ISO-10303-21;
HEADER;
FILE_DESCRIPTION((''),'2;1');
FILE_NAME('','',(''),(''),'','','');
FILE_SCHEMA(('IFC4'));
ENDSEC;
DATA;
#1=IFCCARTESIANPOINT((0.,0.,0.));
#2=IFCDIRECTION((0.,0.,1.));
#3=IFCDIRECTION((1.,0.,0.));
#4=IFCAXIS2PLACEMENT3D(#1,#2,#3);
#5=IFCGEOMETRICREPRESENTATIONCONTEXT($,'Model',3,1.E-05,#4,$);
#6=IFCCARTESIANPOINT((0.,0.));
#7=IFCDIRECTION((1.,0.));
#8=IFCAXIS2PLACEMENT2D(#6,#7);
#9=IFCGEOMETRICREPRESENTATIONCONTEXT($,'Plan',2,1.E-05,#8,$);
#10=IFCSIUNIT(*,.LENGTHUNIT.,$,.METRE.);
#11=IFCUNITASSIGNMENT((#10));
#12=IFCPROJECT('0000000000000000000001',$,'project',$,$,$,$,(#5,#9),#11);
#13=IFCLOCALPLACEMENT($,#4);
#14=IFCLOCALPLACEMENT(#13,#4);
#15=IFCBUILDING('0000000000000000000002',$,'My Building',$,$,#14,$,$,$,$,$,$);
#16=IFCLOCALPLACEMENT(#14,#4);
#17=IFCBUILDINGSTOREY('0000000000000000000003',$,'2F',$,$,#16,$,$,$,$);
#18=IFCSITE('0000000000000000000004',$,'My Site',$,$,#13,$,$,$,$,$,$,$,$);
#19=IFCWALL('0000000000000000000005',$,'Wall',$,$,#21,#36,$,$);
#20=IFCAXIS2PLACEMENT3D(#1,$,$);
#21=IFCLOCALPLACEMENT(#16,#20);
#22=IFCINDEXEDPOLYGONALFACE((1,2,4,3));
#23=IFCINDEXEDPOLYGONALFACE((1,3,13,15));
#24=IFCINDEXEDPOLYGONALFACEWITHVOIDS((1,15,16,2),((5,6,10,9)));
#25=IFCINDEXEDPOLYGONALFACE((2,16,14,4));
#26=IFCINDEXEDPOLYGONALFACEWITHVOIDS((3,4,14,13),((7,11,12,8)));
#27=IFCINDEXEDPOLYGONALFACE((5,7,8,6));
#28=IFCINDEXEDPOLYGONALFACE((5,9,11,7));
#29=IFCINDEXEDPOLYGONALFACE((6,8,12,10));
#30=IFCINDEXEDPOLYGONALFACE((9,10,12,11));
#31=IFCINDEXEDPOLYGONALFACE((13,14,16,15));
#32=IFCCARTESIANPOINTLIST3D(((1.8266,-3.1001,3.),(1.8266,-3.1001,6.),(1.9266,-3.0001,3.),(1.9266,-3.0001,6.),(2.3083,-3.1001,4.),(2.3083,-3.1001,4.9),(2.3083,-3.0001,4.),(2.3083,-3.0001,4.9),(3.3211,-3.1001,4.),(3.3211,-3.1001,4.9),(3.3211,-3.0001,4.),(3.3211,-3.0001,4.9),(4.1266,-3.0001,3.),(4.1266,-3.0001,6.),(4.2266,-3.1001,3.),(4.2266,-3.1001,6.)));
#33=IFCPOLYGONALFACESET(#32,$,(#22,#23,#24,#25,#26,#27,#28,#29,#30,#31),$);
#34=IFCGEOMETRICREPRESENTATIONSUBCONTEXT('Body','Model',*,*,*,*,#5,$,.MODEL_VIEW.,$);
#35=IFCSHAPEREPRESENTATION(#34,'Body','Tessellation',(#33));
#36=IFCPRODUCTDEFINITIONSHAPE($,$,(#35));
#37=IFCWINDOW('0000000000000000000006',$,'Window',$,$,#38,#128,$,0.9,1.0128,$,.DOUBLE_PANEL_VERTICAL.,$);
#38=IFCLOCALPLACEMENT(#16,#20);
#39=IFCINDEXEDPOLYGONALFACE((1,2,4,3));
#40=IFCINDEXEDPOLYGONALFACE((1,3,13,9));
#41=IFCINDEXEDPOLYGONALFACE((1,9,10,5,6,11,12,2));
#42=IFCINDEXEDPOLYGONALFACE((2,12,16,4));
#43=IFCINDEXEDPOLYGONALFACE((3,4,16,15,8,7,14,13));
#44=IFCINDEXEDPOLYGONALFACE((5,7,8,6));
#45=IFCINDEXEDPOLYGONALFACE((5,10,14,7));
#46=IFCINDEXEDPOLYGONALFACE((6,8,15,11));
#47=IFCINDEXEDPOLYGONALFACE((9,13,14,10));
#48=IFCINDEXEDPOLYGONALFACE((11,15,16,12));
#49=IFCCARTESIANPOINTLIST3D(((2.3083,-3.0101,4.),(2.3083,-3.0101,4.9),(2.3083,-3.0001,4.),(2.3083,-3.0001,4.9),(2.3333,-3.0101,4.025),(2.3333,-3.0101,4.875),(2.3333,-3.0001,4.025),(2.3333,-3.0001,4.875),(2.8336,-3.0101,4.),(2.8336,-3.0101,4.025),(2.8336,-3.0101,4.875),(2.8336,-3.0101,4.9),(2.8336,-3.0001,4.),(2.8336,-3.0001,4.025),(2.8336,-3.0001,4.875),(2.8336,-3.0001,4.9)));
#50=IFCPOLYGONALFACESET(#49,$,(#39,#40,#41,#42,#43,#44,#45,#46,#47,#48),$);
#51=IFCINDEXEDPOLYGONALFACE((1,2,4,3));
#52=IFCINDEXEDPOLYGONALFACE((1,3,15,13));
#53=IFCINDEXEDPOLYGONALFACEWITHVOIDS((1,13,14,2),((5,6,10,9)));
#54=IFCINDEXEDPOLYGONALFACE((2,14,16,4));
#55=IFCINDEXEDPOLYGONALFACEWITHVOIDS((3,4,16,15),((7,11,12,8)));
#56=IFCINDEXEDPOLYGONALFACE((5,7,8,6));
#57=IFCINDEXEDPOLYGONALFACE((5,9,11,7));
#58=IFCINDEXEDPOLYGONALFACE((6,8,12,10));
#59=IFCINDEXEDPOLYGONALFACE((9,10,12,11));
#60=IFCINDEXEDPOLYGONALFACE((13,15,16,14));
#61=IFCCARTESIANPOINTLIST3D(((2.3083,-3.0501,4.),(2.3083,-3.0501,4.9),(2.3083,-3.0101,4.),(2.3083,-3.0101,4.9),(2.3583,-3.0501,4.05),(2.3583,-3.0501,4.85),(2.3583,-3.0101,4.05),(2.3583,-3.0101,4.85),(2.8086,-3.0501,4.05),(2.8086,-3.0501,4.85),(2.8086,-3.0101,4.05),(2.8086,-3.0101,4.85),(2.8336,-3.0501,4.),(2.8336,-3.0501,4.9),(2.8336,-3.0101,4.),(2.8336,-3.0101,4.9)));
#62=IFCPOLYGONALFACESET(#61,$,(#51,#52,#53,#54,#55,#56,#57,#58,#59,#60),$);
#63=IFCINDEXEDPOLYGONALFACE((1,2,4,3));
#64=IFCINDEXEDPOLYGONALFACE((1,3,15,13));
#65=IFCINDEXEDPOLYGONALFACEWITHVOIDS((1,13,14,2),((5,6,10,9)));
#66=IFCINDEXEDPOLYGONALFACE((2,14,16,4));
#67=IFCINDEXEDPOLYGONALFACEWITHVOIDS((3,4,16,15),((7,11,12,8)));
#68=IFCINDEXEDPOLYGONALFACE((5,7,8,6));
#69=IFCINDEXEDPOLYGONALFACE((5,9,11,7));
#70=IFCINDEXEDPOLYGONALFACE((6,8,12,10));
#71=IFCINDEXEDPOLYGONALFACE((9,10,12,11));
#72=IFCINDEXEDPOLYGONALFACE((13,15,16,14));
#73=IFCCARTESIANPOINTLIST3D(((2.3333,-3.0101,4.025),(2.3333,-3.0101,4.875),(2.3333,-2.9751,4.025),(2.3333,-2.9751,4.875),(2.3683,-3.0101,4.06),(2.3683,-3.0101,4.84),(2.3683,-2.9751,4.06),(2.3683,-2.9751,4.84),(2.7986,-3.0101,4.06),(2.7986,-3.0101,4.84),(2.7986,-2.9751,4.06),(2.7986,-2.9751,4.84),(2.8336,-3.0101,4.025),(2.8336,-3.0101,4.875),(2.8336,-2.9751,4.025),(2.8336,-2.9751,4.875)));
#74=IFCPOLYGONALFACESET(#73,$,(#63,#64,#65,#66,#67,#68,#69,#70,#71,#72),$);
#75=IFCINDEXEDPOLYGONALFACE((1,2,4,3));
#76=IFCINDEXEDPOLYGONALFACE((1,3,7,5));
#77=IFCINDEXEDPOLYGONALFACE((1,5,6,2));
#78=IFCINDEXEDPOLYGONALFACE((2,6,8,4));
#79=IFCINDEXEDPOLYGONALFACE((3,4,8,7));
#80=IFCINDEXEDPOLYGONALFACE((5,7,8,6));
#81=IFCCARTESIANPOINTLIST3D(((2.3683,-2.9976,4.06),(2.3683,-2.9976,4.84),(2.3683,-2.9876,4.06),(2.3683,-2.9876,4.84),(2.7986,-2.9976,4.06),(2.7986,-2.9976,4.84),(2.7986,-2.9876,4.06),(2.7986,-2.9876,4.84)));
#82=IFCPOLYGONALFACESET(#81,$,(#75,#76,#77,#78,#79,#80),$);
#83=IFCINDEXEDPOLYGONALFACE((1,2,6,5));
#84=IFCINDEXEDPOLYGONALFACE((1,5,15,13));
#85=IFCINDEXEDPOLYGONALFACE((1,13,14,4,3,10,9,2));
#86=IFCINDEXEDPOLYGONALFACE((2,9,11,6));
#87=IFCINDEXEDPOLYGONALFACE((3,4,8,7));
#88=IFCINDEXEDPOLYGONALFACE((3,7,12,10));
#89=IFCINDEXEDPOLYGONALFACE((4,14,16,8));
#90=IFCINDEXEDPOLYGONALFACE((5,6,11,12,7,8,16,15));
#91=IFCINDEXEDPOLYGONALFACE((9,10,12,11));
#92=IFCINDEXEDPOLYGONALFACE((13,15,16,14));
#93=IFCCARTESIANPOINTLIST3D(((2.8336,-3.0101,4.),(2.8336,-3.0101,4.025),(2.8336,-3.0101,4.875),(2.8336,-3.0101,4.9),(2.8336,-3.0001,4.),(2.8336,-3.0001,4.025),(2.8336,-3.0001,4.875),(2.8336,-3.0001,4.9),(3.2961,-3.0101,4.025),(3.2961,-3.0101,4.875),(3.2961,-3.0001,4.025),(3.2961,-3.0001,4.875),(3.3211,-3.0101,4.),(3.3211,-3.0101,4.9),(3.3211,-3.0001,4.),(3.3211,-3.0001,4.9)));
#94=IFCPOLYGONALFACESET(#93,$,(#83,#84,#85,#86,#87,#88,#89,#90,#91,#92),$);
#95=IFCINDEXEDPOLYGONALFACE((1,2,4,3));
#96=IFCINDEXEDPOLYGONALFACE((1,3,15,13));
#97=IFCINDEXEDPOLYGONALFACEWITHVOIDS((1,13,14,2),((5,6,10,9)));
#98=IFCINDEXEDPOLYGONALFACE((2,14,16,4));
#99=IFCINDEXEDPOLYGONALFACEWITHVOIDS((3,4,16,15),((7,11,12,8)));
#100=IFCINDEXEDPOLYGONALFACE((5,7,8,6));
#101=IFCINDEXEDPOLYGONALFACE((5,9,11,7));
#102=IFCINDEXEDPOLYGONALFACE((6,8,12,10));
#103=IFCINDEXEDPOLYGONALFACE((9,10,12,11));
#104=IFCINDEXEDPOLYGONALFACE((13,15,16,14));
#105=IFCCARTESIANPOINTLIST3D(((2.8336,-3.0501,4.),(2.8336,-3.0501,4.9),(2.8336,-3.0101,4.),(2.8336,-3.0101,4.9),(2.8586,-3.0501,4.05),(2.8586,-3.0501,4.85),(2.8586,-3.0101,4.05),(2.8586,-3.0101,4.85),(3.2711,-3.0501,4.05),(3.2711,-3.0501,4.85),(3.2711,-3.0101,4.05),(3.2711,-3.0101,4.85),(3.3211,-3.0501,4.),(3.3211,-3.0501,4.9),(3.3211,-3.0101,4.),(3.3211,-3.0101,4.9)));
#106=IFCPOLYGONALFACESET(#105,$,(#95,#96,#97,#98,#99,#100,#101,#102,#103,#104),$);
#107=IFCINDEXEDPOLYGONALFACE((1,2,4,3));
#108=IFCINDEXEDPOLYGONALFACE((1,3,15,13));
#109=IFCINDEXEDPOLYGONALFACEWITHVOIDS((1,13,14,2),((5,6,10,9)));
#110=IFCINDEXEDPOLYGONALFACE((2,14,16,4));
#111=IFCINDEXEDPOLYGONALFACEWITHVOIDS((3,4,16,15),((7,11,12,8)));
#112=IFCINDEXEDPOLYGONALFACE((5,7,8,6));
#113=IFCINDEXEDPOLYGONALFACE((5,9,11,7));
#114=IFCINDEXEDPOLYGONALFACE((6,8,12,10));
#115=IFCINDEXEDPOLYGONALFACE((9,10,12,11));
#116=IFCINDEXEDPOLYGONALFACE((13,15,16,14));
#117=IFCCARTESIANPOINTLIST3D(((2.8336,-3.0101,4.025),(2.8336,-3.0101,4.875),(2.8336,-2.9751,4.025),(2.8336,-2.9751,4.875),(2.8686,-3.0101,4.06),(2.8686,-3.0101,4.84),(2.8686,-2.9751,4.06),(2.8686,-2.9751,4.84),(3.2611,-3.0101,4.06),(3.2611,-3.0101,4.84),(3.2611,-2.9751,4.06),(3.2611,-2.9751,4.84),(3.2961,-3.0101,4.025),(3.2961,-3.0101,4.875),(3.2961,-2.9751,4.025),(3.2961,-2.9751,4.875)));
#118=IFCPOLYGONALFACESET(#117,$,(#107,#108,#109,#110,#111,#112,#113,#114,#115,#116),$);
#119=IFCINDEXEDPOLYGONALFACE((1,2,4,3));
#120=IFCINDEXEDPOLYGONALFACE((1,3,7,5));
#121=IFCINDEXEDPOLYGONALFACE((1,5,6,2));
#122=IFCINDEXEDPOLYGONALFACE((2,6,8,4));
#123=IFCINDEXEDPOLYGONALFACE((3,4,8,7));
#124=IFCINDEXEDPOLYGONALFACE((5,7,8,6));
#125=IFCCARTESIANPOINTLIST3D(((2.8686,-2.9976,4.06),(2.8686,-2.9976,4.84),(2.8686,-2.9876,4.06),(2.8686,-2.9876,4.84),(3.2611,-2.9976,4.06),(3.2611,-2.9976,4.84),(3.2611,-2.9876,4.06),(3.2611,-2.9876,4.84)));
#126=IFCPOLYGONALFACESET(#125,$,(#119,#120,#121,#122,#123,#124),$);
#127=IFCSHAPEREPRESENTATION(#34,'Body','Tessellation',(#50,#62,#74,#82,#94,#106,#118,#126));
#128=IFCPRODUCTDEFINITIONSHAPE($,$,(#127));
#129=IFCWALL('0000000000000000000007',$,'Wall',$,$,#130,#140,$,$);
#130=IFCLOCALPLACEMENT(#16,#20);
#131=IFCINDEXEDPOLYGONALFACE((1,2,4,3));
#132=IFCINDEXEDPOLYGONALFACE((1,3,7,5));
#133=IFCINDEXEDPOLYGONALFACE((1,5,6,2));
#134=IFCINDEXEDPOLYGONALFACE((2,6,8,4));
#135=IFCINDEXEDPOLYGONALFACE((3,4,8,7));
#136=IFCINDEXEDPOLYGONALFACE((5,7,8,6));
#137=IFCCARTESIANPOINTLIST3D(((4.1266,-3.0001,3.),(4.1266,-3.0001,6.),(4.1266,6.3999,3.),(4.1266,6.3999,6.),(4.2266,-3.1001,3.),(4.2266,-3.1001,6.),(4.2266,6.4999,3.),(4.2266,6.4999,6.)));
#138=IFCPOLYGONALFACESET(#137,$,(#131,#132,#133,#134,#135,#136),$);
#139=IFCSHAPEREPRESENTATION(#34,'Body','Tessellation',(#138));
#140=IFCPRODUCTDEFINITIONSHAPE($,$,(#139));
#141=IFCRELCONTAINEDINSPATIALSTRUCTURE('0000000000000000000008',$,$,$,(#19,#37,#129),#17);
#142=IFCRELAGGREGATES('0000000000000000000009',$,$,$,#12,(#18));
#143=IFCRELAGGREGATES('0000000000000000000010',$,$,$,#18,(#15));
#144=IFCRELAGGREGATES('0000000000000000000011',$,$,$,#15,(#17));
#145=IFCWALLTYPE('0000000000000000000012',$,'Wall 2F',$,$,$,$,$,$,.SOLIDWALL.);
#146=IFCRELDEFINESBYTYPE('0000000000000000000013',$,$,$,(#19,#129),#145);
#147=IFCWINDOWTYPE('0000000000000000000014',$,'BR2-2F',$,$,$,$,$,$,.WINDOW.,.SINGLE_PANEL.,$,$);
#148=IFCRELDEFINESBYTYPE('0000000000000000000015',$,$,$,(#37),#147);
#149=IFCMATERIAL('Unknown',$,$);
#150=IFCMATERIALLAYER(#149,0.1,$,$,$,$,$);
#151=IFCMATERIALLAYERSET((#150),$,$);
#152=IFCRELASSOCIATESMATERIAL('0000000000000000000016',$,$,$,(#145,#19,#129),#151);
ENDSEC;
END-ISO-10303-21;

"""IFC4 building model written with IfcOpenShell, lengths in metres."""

from ifc_helpers import new_model, entity, si_unit, frame, origin_with_axes, origin_2d_with_axis, place, context, subcontext, project, spatial, line, indexed_curve, outline, extrude, shape, source, transform, mapped, material, layer, layer_set, layer_usage, type_object, type_shapes, element, fill, save


model = new_model("IFC4")

# Units and contexts
model_context = context("Model", 3, precision=1e-05, world=origin_with_axes())
plan_context = context("Plan", 2, precision=1e-05, world=origin_2d_with_axis())
body_context_1 = subcontext(model_context, "Body", "Model", "MODEL_VIEW")
body_context_2 = subcontext(plan_context, "Body", "Plan", "PLAN_VIEW")
ifc_project = project(units=[si_unit("LENGTHUNIT", "METRE")], contexts=[model_context, plan_context])

# Site, building, storey
site_placement = place(None, origin_with_axes())
site = spatial("IfcSite", under=ifc_project, at=site_placement, Name="My Site")
building_placement = place(site_placement, origin_with_axes())
building = spatial("IfcBuilding", under=site, at=building_placement, Name="My Building")
storey_placement = place(building_placement, origin_with_axes())
storey = spatial("IfcBuildingStorey", under=building, at=storey_placement, Name="2F")

# Shared definitions
ifc_material = material(Name="Unknown")

# Shared definitions
ifc_layer = layer(ifc_material, 0.1)
ifc_layer_set = layer_set([ifc_layer])
wall_type = type_object("IfcWallType", Name="Wall 2F", PredefinedType="SOLIDWALL", material=ifc_layer_set)

# Wall, opening, window
ifc_layer_usage_1 = layer_usage(ifc_layer_set, "AXIS2", "POSITIVE", 0.0)
wall_1_placement = place(storey_placement, frame((1.8266, -3.1001, 3.0), z_axis=(0.0, 0.0, 1.0), x_axis=(1.0, 0.0, 0.0)))
wall_1 = element("IfcWall", 1, at=wall_1_placement, inside=storey, type_object=wall_type, material=ifc_layer_usage_1, Name="Wall", context=body_context_1, shape_type="SweptSolid", body=[
    extrude(outline(indexed_curve([(0.0, 0.0), (0.1, 0.1), (2.3, 0.1), (2.4, 0.0)], segments=[line(1, 2, 3, 4, 1)])), origin_with_axes(), (0.0, 0.0, 1.0), 3.0),
])
shared_shape_1 = source(origin_with_axes(), body_context_1, "Body", "SweptSolid", [
    extrude(outline(indexed_curve([(0.0, 0.0), (1.0128, 0.0), (1.0128, 0.9), (0.0, 0.9)], segments=[line(1, 2, 3, 4, 1)])), frame((0.0, -0.6, 0.0), z_axis=(0.0, -1.0, 0.0), x_axis=(1.0, 0.0, 0.0)), (0.0, 0.0, -1.0), 1.2),
])
opening_1_placement = place(wall_1_placement, frame((0.4817, 0.0, 1.0), z_axis=(0.0, 0.0, 1.0), x_axis=(1.0, 0.0, 0.0)))
opening_1 = element("IfcOpeningElement", 2, at=opening_1_placement, cuts=wall_1, PredefinedType="OPENING", context=body_context_1, shape_type="MappedRepresentation", body=[
    mapped(shared_shape_1, transform((0.0, 0.0, 0.0), x_axis=(1.0, 0.0, 0.0), y_axis=(0.0, 1.0, 0.0), z_axis=(0.0, 0.0, 1.0), scale=1.0)),
])
window_type = type_object("IfcWindowType", Name="BR2-2F", PartitioningType="SINGLE_PANEL", PredefinedType="WINDOW")
shared_shape_2 = source(origin_with_axes(), body_context_1, "Body", "SweptSolid", [
    extrude(outline(indexed_curve([(0.5254, 0.0), (0.0, 0.0), (0.0, 0.9), (0.5254, 0.9), (0.5254, 0.875), (0.025, 0.875), (0.025, 0.025), (0.5254, 0.025)], segments=[line(1, 2, 3, 4, 5, 6, 7, 8, 1)])), frame((0.0, 0.09, 0.0), z_axis=(0.0, -1.0, 0.0), x_axis=(1.0, 0.0, 0.0)), (0.0, 0.0, -1.0), 0.01),
    extrude(outline(indexed_curve([(0.0, 0.0), (0.5254, 0.0), (0.5254, 0.9), (0.0, 0.9)], segments=[line(1, 2, 3, 4, 1)]), holes=[indexed_curve([(0.05, 0.05), (0.5004, 0.05), (0.5004, 0.85), (0.05, 0.85)], segments=[line(1, 2, 3, 4, 1)])]), frame((0.0, 0.05, 0.0), z_axis=(0.0, -1.0, 0.0), x_axis=(1.0, 0.0, 0.0)), (0.0, 0.0, -1.0), 0.04),
    extrude(outline(indexed_curve([(0.0, 0.0), (0.5004, 0.0), (0.5004, 0.85), (0.0, 0.85)], segments=[line(1, 2, 3, 4, 1)]), holes=[indexed_curve([(0.035, 0.035), (0.4654, 0.035), (0.4654, 0.815), (0.035, 0.815)], segments=[line(1, 2, 3, 4, 1)])]), frame((0.025, 0.09, 0.025), z_axis=(0.0, -1.0, 0.0), x_axis=(1.0, 0.0, 0.0)), (0.0, 0.0, -1.0), 0.035),
    extrude(outline(indexed_curve([(0.035, 0.035), (0.4654, 0.035), (0.4654, 0.815), (0.035, 0.815)], segments=[line(1, 2, 3, 4, 1)])), frame((0.025, 0.1025, 0.025), z_axis=(0.0, -1.0, 0.0), x_axis=(1.0, 0.0, 0.0)), (0.0, 0.0, -1.0), 0.01),
    extrude(outline(indexed_curve([(0.0, 0.9), (0.4875, 0.9), (0.4875, 0.0), (0.0, 0.0), (0.0, 0.025), (0.4625, 0.025), (0.4625, 0.875), (0.0, 0.875)], segments=[line(1, 2, 3, 4, 5, 6, 7, 8, 1)])), frame((0.5254, 0.09, 0.0), z_axis=(0.0, -1.0, 0.0), x_axis=(1.0, 0.0, 0.0)), (0.0, 0.0, -1.0), 0.01),
    extrude(outline(indexed_curve([(0.0, 0.0), (0.4875, 0.0), (0.4875, 0.9), (0.0, 0.9)], segments=[line(1, 2, 3, 4, 1)]), holes=[indexed_curve([(0.025, 0.05), (0.4375, 0.05), (0.4375, 0.85), (0.025, 0.85)], segments=[line(1, 2, 3, 4, 1)])]), frame((0.5254, 0.05, 0.0), z_axis=(0.0, -1.0, 0.0), x_axis=(1.0, 0.0, 0.0)), (0.0, 0.0, -1.0), 0.04),
    extrude(outline(indexed_curve([(0.0, 0.0), (0.4625, 0.0), (0.4625, 0.85), (0.0, 0.85)], segments=[line(1, 2, 3, 4, 1)]), holes=[indexed_curve([(0.035, 0.035), (0.4275, 0.035), (0.4275, 0.815), (0.035, 0.815)], segments=[line(1, 2, 3, 4, 1)])]), frame((0.5254, 0.09, 0.025), z_axis=(0.0, -1.0, 0.0), x_axis=(1.0, 0.0, 0.0)), (0.0, 0.0, -1.0), 0.035),
    extrude(outline(indexed_curve([(0.035, 0.035), (0.4275, 0.035), (0.4275, 0.815), (0.035, 0.815)], segments=[line(1, 2, 3, 4, 1)])), frame((0.5254, 0.1025, 0.025), z_axis=(0.0, -1.0, 0.0), x_axis=(1.0, 0.0, 0.0)), (0.0, 0.0, -1.0), 0.01),
])
shared_shape_3 = source(origin_with_axes(), body_context_2, "Body", "Curve2D", [
    entity("IfcIndexedPolyCurve", entity("IfcCartesianPointList2D", [[0.05, 0.05], [0.5004, 0.05]])),
    entity("IfcIndexedPolyCurve", entity("IfcCartesianPointList2D", [[0.0, 0.1], [0.025, 0.1], [0.025, 0.09], [0.05, 0.09], [0.05, 0.05], [0.0, 0.05]]), [entity("IfcLineIndex", [1, 2, 3, 4, 5, 6, 1])]),
    entity("IfcIndexedPolyCurve", entity("IfcCartesianPointList2D", [[0.5254, 0.1], [0.5254, 0.1], [0.5254, 0.09], [0.5004, 0.09], [0.5004, 0.05], [0.5254, 0.05]])),
    entity("IfcIndexedPolyCurve", entity("IfcCartesianPointList2D", [[0.025, 0.09], [0.06, 0.09], [0.06, 0.125], [0.025, 0.125]]), [entity("IfcLineIndex", [1, 2, 3, 4, 1])]),
    entity("IfcIndexedPolyCurve", entity("IfcCartesianPointList2D", [[0.5254, 0.09], [0.4904, 0.09], [0.4904, 0.125], [0.5254, 0.125]]), [entity("IfcLineIndex", [1, 2, 3, 4, 1])]),
    entity("IfcIndexedPolyCurve", entity("IfcCartesianPointList2D", [[0.06, 0.09], [0.4904, 0.09]])),
    entity("IfcIndexedPolyCurve", entity("IfcCartesianPointList2D", [[0.06, 0.125], [0.4904, 0.125]])),
    entity("IfcIndexedPolyCurve", entity("IfcCartesianPointList2D", [[0.06, 0.1075], [0.4904, 0.1075]])),
    entity("IfcIndexedPolyCurve", entity("IfcCartesianPointList2D", [[0.5504, 0.05], [0.9628, 0.05]])),
    entity("IfcIndexedPolyCurve", entity("IfcCartesianPointList2D", [[0.5254, 0.1], [0.5254, 0.1], [0.5254, 0.09], [0.5504, 0.09], [0.5504, 0.05], [0.5254, 0.05]])),
    entity("IfcIndexedPolyCurve", entity("IfcCartesianPointList2D", [[1.0128, 0.1], [0.9878, 0.1], [0.9878, 0.09], [0.9628, 0.09], [0.9628, 0.05], [1.0128, 0.05]]), [entity("IfcLineIndex", [1, 2, 3, 4, 5, 6, 1])]),
    entity("IfcIndexedPolyCurve", entity("IfcCartesianPointList2D", [[0.5254, 0.09], [0.5604, 0.09], [0.5604, 0.125], [0.5254, 0.125]]), [entity("IfcLineIndex", [1, 2, 3, 4, 1])]),
    entity("IfcIndexedPolyCurve", entity("IfcCartesianPointList2D", [[0.9878, 0.09], [0.9528, 0.09], [0.9528, 0.125], [0.9878, 0.125]]), [entity("IfcLineIndex", [1, 2, 3, 4, 1])]),
    entity("IfcIndexedPolyCurve", entity("IfcCartesianPointList2D", [[0.5604, 0.09], [0.9528, 0.09]])),
    entity("IfcIndexedPolyCurve", entity("IfcCartesianPointList2D", [[0.5604, 0.125], [0.9528, 0.125]])),
    entity("IfcIndexedPolyCurve", entity("IfcCartesianPointList2D", [[0.5604, 0.1075], [0.9528, 0.1075]])),
])
type_shapes(window_type, [shared_shape_2, shared_shape_3])
window_placement = place(opening_1_placement, frame((0.0, 0.0, 0.0), z_axis=(0.0, 0.0, 1.0), x_axis=(1.0, 0.0, 0.0)))
window = element("IfcWindow", 3, at=window_placement, inside=storey, type_object=window_type, Name="Window", OverallHeight=0.9, OverallWidth=1.0128, PartitioningType="DOUBLE_PANEL_VERTICAL", shapes=[
    shape(body_context_1, "Body", "MappedRepresentation", [mapped(shared_shape_2, transform((0.0, 0.0, 0.0), x_axis=(1.0, 0.0, 0.0), y_axis=(0.0, 1.0, 0.0), z_axis=(0.0, 0.0, 1.0), scale=1.0))]),
    shape(body_context_2, "Body", "MappedRepresentation", [mapped(shared_shape_3, transform((0.0, 0.0, 0.0), x_axis=(1.0, 0.0, 0.0), y_axis=(0.0, 1.0, 0.0), z_axis=(0.0, 0.0, 1.0), scale=1.0))]),
])
fill(opening_1, window)

# Wall
ifc_layer_usage_2 = layer_usage(ifc_layer_set, "AXIS2", "POSITIVE", 0.0)
wall_2_placement = place(storey_placement, frame((4.2266, -3.1001, 3.0), z_axis=(0.0, 0.0, 1.0), x_axis=(0.0, 1.0, 0.0)))
element("IfcWall", 4, at=wall_2_placement, inside=storey, type_object=wall_type, material=ifc_layer_usage_2, Name="Wall", context=body_context_1, shape_type="SweptSolid", body=[
    extrude(outline(indexed_curve([(0.0, 0.0), (0.1, 0.1), (9.5, 0.1), (9.6, 0.0)], segments=[line(1, 2, 3, 4, 1)])), origin_with_axes(), (0.0, 0.0, 1.0), 3.0),
])

save(model, "model.ifc")
